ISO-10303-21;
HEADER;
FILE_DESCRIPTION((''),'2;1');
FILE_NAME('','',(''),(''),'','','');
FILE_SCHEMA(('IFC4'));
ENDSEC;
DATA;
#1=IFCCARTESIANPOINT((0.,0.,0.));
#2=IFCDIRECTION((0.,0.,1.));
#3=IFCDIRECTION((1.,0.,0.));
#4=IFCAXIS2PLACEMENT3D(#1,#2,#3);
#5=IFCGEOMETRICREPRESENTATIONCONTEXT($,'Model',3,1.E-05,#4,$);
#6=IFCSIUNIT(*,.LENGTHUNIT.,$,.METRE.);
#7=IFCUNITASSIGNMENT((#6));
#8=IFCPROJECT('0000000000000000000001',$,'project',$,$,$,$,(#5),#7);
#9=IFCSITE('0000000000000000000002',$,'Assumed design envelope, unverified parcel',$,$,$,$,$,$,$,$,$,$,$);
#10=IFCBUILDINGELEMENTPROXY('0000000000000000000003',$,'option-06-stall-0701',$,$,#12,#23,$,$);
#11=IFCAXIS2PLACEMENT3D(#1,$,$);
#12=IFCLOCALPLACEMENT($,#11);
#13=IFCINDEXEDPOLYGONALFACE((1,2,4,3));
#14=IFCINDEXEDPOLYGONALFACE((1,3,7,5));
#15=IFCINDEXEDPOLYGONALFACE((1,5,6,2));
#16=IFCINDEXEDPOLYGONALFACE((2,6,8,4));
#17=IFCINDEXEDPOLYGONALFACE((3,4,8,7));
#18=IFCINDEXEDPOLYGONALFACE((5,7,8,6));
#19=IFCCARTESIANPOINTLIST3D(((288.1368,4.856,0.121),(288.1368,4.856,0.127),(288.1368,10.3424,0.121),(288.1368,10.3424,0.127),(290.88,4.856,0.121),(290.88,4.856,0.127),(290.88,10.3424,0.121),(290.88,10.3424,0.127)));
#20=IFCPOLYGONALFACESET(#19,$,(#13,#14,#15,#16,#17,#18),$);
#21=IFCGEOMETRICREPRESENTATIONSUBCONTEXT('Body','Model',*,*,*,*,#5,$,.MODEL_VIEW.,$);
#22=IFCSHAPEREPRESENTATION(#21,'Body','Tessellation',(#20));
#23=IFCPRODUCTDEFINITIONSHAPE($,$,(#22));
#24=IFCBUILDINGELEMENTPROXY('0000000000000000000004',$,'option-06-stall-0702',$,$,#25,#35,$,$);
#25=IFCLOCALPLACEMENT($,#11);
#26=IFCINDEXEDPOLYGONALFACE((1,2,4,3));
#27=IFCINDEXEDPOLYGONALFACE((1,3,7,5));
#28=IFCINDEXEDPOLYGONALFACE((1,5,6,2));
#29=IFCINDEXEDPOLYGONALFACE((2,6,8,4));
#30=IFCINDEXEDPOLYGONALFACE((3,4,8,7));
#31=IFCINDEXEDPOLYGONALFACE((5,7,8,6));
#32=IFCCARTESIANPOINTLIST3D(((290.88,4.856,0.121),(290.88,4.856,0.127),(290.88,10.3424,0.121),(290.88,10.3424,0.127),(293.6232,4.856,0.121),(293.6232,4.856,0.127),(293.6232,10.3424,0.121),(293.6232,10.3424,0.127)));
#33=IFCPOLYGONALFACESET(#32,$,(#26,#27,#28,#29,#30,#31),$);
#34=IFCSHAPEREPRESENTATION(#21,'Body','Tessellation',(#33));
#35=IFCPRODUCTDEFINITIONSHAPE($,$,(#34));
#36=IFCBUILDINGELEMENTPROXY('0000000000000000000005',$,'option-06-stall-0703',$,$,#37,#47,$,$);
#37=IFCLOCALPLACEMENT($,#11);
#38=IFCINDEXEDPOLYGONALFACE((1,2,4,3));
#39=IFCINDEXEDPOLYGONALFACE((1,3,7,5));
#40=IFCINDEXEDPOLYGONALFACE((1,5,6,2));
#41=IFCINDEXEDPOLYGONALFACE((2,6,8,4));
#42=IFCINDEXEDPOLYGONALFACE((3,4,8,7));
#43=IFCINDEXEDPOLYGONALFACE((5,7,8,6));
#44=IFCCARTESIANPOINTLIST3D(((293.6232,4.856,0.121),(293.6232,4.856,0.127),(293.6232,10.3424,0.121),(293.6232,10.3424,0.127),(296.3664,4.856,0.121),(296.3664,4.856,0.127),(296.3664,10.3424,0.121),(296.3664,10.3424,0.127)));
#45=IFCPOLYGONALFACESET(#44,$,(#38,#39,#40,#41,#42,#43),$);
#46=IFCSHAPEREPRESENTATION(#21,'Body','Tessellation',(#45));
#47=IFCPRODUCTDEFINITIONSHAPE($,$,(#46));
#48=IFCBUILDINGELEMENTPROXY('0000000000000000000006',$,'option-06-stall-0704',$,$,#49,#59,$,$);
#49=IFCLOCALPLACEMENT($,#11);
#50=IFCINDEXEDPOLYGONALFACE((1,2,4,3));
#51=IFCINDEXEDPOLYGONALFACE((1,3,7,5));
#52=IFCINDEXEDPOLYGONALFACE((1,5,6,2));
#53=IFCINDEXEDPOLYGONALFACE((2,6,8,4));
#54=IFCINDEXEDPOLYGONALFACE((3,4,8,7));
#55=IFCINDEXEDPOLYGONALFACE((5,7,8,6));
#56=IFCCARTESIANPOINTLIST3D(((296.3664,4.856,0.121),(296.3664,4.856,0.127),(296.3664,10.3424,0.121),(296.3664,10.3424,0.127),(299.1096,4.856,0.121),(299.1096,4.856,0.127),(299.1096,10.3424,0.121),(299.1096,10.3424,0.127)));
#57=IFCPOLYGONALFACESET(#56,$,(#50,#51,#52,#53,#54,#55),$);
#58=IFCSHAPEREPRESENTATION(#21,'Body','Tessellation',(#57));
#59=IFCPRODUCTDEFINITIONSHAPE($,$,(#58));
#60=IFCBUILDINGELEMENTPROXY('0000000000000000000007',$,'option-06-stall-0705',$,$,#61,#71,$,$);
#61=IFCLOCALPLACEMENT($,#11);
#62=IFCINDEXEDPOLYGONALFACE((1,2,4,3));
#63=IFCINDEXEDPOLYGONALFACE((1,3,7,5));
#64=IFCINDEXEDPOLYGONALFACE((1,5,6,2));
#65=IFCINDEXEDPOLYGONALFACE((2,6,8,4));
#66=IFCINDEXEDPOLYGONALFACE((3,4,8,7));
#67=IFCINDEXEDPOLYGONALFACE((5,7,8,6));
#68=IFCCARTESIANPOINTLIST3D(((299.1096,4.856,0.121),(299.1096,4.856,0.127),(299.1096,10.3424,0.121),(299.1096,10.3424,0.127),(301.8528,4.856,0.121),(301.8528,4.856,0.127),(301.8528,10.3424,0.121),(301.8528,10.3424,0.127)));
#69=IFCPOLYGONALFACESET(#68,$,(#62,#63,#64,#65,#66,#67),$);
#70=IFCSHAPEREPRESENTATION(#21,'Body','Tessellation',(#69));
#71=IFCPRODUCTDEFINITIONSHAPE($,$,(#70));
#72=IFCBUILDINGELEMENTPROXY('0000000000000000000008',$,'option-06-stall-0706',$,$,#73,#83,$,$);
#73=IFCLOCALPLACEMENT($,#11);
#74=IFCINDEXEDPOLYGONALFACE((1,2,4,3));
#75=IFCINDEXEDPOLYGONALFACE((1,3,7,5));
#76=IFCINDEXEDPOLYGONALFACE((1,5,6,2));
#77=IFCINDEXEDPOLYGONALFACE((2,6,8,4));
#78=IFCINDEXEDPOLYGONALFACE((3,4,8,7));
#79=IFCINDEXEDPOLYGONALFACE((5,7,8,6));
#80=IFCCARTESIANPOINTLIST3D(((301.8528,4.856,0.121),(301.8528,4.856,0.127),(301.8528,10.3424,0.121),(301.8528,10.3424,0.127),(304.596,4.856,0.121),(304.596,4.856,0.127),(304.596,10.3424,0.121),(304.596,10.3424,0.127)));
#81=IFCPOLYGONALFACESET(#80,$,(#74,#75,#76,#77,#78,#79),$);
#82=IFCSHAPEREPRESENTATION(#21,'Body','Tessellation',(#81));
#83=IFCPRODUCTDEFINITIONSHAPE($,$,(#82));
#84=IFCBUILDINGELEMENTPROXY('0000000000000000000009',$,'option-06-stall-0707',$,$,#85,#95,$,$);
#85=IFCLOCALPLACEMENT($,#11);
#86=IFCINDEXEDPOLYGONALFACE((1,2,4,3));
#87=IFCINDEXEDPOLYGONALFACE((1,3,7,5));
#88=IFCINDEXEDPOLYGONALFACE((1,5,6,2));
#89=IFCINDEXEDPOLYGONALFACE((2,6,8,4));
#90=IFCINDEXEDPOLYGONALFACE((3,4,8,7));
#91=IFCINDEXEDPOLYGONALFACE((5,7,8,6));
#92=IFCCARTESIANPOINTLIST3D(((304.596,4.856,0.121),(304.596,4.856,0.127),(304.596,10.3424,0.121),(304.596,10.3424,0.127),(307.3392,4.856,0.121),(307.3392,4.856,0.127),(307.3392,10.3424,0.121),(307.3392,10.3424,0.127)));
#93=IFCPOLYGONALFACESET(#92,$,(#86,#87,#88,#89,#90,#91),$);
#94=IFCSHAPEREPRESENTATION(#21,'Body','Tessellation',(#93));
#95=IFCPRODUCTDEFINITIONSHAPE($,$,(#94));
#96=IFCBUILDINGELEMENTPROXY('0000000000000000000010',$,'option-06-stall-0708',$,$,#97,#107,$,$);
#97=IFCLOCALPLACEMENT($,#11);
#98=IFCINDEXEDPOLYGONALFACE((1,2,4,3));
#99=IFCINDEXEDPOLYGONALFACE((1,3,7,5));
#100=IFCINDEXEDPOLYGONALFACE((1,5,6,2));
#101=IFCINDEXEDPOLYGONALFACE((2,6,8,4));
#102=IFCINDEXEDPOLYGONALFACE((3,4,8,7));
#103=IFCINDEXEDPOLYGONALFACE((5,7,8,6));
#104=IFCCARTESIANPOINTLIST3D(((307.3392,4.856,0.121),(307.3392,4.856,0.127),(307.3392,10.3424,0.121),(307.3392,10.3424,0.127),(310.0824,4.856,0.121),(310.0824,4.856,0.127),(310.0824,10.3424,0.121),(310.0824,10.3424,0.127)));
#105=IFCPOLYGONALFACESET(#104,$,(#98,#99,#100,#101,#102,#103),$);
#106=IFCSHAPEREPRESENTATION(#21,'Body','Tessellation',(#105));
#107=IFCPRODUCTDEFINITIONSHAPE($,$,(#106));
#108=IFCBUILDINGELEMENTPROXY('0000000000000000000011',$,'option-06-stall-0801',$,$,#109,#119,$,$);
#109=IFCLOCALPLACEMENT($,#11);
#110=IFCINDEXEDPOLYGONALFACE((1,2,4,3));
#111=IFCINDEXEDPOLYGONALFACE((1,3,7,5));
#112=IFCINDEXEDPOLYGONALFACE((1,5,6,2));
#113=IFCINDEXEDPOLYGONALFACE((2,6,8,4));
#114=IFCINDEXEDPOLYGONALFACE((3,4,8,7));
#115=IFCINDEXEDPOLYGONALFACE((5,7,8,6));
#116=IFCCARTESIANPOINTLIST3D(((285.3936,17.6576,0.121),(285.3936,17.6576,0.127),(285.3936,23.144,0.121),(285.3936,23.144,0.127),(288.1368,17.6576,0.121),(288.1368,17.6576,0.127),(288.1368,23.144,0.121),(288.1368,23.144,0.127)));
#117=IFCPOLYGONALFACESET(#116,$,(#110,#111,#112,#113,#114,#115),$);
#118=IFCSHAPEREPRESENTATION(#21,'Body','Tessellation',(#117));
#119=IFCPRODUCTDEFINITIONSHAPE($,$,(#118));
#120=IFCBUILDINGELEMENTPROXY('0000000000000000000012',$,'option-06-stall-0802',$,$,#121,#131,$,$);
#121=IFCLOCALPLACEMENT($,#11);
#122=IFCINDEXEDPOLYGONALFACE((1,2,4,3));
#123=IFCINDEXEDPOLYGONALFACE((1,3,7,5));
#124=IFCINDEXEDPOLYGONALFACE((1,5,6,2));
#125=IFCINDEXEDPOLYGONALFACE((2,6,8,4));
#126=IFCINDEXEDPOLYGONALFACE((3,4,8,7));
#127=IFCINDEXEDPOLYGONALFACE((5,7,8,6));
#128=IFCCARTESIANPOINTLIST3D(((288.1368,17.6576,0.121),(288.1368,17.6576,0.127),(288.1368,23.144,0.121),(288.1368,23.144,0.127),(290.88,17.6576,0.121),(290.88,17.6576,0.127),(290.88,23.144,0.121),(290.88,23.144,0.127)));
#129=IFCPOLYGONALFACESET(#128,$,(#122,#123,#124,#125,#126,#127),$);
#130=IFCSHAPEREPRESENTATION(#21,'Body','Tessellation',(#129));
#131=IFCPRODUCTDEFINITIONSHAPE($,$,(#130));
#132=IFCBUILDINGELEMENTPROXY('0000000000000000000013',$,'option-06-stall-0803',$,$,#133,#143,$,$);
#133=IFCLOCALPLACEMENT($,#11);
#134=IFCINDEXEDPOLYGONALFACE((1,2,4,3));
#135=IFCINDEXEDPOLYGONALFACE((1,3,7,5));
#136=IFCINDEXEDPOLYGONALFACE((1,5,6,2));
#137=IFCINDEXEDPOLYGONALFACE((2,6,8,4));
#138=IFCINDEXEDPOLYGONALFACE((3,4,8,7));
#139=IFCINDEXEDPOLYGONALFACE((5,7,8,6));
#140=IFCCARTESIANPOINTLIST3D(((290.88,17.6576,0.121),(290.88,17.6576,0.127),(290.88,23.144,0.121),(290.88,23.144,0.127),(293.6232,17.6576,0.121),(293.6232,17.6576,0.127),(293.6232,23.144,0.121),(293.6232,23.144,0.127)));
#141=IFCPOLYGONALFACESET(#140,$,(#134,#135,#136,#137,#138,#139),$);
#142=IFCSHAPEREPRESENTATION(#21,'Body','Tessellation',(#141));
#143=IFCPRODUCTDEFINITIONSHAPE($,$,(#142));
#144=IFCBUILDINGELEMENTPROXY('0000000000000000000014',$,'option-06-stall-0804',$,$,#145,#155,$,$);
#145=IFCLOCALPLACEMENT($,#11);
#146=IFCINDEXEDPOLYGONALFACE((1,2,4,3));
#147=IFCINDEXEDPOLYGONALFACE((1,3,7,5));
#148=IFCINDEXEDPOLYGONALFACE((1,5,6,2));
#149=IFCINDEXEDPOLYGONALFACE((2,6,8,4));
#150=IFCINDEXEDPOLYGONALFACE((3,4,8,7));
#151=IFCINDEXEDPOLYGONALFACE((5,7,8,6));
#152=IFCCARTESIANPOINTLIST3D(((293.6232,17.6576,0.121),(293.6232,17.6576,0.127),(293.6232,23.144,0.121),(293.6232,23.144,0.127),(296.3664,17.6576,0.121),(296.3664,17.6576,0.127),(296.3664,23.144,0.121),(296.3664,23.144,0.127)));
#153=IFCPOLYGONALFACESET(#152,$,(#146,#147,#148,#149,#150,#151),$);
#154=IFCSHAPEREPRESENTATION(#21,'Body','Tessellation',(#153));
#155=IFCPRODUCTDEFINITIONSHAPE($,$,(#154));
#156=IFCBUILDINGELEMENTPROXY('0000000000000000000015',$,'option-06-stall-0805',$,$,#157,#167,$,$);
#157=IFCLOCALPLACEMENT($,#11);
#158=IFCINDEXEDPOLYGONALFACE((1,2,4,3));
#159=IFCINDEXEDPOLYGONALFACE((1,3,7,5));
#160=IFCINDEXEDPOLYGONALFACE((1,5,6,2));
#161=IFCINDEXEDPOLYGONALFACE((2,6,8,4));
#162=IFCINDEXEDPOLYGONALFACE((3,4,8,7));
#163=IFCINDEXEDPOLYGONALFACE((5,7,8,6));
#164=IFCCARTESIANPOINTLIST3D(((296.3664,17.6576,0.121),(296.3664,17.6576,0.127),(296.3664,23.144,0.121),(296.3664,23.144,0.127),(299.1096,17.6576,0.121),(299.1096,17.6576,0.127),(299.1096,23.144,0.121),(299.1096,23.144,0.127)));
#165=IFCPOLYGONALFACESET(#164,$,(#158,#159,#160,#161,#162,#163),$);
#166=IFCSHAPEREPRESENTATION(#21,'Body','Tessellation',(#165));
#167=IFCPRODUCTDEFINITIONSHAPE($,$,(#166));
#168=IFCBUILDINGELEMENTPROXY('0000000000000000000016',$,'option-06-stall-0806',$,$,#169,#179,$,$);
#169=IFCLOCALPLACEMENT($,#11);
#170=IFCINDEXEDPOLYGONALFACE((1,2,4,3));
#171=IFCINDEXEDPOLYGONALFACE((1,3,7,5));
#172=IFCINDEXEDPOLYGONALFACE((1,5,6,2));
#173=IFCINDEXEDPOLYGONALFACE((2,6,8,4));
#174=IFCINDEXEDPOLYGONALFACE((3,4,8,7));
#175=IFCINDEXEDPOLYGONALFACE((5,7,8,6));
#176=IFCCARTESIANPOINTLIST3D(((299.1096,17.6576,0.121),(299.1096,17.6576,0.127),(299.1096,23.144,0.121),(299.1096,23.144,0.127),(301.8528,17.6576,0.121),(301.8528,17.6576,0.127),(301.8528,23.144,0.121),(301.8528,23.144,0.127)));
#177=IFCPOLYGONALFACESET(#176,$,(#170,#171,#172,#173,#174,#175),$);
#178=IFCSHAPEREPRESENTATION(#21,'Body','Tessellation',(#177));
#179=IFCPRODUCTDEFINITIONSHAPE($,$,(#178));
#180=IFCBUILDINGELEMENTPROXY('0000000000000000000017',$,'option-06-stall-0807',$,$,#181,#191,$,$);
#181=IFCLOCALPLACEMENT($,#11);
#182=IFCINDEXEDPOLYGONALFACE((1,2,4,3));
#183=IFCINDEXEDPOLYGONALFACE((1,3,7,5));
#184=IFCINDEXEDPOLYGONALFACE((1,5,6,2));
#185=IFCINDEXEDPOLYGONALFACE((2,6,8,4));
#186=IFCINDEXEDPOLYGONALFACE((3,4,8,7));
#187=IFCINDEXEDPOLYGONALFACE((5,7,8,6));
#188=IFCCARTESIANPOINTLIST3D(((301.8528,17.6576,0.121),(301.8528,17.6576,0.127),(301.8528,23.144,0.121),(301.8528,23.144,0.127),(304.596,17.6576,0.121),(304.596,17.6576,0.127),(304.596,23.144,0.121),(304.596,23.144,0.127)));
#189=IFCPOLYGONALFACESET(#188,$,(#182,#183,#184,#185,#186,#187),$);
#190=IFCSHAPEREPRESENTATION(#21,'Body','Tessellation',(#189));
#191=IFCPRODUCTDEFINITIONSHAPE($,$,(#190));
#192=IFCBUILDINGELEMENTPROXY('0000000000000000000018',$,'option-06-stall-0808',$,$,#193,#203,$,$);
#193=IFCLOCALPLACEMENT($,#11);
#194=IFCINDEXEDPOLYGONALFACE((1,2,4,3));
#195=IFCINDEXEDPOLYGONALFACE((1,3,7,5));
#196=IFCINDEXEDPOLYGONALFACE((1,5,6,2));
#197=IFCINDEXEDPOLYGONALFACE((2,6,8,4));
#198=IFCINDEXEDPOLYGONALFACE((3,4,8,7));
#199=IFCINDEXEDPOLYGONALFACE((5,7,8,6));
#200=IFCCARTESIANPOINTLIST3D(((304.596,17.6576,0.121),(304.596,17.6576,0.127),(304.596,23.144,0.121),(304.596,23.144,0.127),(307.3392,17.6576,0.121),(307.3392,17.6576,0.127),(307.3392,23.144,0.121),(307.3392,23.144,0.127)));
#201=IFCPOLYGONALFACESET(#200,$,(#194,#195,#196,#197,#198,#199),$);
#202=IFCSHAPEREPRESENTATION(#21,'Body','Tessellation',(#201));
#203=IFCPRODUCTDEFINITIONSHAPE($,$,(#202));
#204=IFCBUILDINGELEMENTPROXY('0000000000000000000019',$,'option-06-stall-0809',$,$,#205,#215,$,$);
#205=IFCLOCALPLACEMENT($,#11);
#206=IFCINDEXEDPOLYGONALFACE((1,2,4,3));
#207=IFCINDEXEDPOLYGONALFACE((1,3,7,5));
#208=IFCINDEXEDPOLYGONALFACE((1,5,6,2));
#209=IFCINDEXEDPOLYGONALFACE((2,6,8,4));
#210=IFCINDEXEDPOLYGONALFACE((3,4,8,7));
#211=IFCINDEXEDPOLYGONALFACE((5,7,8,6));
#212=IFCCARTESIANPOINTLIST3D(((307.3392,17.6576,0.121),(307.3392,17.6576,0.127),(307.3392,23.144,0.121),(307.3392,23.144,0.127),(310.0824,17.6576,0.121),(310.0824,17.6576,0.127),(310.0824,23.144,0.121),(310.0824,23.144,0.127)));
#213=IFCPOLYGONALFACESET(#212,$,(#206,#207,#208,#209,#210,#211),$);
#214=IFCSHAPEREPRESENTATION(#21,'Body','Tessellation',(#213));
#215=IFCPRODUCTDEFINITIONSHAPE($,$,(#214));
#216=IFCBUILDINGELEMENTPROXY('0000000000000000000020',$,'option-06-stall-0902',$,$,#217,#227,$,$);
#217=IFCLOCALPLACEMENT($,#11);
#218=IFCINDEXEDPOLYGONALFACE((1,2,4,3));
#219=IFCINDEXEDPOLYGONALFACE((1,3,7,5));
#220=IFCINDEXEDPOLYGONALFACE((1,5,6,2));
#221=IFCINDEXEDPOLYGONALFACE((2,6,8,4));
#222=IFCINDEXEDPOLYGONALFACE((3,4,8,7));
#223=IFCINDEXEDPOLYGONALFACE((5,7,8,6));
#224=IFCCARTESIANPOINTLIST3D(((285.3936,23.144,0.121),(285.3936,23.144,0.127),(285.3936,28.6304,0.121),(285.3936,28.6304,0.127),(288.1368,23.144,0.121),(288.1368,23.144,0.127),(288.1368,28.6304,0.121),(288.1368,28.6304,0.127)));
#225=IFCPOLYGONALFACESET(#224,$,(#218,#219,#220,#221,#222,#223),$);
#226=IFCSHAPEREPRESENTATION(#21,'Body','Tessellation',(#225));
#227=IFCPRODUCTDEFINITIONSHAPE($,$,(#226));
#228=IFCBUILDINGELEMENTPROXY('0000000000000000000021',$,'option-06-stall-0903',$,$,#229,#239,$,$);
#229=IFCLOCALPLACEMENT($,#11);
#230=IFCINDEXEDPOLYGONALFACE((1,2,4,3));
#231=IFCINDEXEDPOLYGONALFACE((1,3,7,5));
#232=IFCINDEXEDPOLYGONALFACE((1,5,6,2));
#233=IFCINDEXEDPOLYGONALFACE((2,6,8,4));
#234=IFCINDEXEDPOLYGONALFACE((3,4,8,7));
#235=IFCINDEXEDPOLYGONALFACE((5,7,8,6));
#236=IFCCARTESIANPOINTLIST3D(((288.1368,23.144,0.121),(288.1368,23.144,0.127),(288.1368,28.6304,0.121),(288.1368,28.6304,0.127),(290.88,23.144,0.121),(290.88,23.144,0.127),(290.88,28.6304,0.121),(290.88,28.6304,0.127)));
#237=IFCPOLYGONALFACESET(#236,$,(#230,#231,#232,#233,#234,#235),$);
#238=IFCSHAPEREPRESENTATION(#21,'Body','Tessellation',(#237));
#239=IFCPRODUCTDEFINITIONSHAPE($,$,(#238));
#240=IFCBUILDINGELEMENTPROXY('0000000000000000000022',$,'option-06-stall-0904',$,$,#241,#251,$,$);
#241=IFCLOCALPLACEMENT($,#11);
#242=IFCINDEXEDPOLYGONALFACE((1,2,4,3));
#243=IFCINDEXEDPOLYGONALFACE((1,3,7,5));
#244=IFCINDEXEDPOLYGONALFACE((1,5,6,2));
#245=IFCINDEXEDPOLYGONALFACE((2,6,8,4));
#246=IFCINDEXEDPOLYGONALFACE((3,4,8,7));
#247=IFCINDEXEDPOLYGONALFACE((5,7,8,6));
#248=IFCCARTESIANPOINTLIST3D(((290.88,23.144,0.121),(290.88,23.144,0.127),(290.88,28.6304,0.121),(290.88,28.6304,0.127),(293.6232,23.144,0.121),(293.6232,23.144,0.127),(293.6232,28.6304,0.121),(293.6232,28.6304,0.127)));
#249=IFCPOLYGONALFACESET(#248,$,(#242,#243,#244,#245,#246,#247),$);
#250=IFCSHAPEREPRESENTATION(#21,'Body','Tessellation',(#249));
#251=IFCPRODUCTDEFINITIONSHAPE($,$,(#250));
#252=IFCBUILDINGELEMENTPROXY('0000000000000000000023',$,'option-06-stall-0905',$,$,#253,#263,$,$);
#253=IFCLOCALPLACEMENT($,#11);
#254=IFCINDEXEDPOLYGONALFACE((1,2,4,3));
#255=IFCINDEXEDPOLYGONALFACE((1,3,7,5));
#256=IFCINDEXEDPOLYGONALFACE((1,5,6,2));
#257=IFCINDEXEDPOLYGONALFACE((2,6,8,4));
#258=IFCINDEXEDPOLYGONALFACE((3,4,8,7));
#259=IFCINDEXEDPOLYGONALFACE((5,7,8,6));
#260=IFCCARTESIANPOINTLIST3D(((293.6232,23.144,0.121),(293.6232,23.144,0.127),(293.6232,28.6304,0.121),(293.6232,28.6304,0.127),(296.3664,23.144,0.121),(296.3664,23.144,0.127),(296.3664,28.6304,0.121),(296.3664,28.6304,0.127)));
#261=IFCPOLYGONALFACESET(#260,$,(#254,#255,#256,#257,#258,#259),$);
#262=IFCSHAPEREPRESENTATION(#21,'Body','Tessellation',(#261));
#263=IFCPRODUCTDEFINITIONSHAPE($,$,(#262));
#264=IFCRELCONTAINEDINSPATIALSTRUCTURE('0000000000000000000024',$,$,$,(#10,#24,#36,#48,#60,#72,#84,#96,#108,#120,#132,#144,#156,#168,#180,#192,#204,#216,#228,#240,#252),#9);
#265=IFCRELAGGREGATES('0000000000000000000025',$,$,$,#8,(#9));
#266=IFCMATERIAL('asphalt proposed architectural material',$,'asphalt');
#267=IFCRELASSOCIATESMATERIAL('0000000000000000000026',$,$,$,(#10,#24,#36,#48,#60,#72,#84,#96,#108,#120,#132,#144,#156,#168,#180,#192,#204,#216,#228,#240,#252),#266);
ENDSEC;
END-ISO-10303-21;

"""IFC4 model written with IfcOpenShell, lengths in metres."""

from ifc_helpers import new_model, si_unit, frame, origin_with_axes, place, context, subcontext, project, spatial, rectangle, extrude, material, element, save


model = new_model("IFC4")

# Units and contexts
model_context = context("Model", 3, precision=1e-05, world=origin_with_axes())
body_context = subcontext(model_context, "Body", "Model", "MODEL_VIEW")
ifc_project = project(units=[si_unit("LENGTHUNIT", "METRE")], contexts=[model_context])

# Site
site = spatial("IfcSite", under=ifc_project, Name="Assumed design envelope, unverified parcel")

# Building element proxies
ifc_material = material(Name="asphalt proposed architectural material", Category="asphalt")
for number, where, z_axis, x_axis, name in (
    (1, (289.5084, 7.5992, 0.121), (0.0, 0.0, 1.0), (1.0, 0.0, 0.0), "option-06-stall-0701"),
    (2, (292.2516, 7.5992, 0.121), (0.0, 0.0, 1.0), (1.0, 0.0, 0.0), "option-06-stall-0702"),
    (3, (294.9948, 7.5992, 0.121), (0.0, 0.0, 1.0), (1.0, 0.0, 0.0), "option-06-stall-0703"),
    (4, (297.738, 7.5992, 0.121), (0.0, 0.0, 1.0), (1.0, 0.0, 0.0), "option-06-stall-0704"),
    (5, (300.4812, 7.5992, 0.121), (0.0, 0.0, 1.0), (1.0, 0.0, 0.0), "option-06-stall-0705"),
    (6, (303.2244, 7.5992, 0.121), (0.0, 0.0, 1.0), (1.0, 0.0, 0.0), "option-06-stall-0706"),
    (7, (305.9676, 7.5992, 0.121), (0.0, 0.0, 1.0), (1.0, 0.0, 0.0), "option-06-stall-0707"),
    (8, (308.7108, 7.5992, 0.121), (0.0, 0.0, 1.0), (1.0, 0.0, 0.0), "option-06-stall-0708"),
):
    element("IfcBuildingElementProxy", number, at=place(None, frame(where, z_axis=z_axis, x_axis=x_axis)), inside=site, material=ifc_material, Name=name, context=body_context, shape_type="SweptSolid", body=[
        extrude(rectangle(XDim=2.7432, YDim=5.4864), origin_with_axes(), (0.0, 0.0, 1.0), 0.006),
    ])
for number, where, z_axis, x_axis, name in (
    (9, (286.7652, 20.4008, 0.121), (0.0, 0.0, 1.0), (1.0, 0.0, 0.0), "option-06-stall-0801"),
    (10, (289.5084, 20.4008, 0.121), (0.0, 0.0, 1.0), (1.0, 0.0, 0.0), "option-06-stall-0802"),
    (11, (292.2516, 20.4008, 0.121), (0.0, 0.0, 1.0), (1.0, 0.0, 0.0), "option-06-stall-0803"),
    (12, (294.9948, 20.4008, 0.121), (0.0, 0.0, 1.0), (1.0, 0.0, 0.0), "option-06-stall-0804"),
    (13, (297.738, 20.4008, 0.121), (0.0, 0.0, 1.0), (1.0, 0.0, 0.0), "option-06-stall-0805"),
    (14, (300.4812, 20.4008, 0.121), (0.0, 0.0, 1.0), (1.0, 0.0, 0.0), "option-06-stall-0806"),
    (15, (303.2244, 20.4008, 0.121), (0.0, 0.0, 1.0), (1.0, 0.0, 0.0), "option-06-stall-0807"),
    (16, (305.9676, 20.4008, 0.121), (0.0, 0.0, 1.0), (1.0, 0.0, 0.0), "option-06-stall-0808"),
    (17, (308.7108, 20.4008, 0.121), (0.0, 0.0, 1.0), (1.0, 0.0, 0.0), "option-06-stall-0809"),
    (18, (286.7652, 25.8872, 0.121), (0.0, 0.0, 1.0), (1.0, 0.0, 0.0), "option-06-stall-0902"),
    (19, (289.5084, 25.8872, 0.121), (0.0, 0.0, 1.0), (1.0, 0.0, 0.0), "option-06-stall-0903"),
    (20, (292.2516, 25.8872, 0.121), (0.0, 0.0, 1.0), (1.0, 0.0, 0.0), "option-06-stall-0904"),
    (21, (294.9948, 25.8872, 0.121), (0.0, 0.0, 1.0), (1.0, 0.0, 0.0), "option-06-stall-0905"),
):
    element("IfcBuildingElementProxy", number, at=place(None, frame(where, z_axis=z_axis, x_axis=x_axis)), inside=site, material=ifc_material, Name=name, context=body_context, shape_type="SweptSolid", body=[
        extrude(rectangle(XDim=2.7432, YDim=5.4864), origin_with_axes(), (0.0, 0.0, 1.0), 0.006),
    ])

save(model, "model.ifc")
